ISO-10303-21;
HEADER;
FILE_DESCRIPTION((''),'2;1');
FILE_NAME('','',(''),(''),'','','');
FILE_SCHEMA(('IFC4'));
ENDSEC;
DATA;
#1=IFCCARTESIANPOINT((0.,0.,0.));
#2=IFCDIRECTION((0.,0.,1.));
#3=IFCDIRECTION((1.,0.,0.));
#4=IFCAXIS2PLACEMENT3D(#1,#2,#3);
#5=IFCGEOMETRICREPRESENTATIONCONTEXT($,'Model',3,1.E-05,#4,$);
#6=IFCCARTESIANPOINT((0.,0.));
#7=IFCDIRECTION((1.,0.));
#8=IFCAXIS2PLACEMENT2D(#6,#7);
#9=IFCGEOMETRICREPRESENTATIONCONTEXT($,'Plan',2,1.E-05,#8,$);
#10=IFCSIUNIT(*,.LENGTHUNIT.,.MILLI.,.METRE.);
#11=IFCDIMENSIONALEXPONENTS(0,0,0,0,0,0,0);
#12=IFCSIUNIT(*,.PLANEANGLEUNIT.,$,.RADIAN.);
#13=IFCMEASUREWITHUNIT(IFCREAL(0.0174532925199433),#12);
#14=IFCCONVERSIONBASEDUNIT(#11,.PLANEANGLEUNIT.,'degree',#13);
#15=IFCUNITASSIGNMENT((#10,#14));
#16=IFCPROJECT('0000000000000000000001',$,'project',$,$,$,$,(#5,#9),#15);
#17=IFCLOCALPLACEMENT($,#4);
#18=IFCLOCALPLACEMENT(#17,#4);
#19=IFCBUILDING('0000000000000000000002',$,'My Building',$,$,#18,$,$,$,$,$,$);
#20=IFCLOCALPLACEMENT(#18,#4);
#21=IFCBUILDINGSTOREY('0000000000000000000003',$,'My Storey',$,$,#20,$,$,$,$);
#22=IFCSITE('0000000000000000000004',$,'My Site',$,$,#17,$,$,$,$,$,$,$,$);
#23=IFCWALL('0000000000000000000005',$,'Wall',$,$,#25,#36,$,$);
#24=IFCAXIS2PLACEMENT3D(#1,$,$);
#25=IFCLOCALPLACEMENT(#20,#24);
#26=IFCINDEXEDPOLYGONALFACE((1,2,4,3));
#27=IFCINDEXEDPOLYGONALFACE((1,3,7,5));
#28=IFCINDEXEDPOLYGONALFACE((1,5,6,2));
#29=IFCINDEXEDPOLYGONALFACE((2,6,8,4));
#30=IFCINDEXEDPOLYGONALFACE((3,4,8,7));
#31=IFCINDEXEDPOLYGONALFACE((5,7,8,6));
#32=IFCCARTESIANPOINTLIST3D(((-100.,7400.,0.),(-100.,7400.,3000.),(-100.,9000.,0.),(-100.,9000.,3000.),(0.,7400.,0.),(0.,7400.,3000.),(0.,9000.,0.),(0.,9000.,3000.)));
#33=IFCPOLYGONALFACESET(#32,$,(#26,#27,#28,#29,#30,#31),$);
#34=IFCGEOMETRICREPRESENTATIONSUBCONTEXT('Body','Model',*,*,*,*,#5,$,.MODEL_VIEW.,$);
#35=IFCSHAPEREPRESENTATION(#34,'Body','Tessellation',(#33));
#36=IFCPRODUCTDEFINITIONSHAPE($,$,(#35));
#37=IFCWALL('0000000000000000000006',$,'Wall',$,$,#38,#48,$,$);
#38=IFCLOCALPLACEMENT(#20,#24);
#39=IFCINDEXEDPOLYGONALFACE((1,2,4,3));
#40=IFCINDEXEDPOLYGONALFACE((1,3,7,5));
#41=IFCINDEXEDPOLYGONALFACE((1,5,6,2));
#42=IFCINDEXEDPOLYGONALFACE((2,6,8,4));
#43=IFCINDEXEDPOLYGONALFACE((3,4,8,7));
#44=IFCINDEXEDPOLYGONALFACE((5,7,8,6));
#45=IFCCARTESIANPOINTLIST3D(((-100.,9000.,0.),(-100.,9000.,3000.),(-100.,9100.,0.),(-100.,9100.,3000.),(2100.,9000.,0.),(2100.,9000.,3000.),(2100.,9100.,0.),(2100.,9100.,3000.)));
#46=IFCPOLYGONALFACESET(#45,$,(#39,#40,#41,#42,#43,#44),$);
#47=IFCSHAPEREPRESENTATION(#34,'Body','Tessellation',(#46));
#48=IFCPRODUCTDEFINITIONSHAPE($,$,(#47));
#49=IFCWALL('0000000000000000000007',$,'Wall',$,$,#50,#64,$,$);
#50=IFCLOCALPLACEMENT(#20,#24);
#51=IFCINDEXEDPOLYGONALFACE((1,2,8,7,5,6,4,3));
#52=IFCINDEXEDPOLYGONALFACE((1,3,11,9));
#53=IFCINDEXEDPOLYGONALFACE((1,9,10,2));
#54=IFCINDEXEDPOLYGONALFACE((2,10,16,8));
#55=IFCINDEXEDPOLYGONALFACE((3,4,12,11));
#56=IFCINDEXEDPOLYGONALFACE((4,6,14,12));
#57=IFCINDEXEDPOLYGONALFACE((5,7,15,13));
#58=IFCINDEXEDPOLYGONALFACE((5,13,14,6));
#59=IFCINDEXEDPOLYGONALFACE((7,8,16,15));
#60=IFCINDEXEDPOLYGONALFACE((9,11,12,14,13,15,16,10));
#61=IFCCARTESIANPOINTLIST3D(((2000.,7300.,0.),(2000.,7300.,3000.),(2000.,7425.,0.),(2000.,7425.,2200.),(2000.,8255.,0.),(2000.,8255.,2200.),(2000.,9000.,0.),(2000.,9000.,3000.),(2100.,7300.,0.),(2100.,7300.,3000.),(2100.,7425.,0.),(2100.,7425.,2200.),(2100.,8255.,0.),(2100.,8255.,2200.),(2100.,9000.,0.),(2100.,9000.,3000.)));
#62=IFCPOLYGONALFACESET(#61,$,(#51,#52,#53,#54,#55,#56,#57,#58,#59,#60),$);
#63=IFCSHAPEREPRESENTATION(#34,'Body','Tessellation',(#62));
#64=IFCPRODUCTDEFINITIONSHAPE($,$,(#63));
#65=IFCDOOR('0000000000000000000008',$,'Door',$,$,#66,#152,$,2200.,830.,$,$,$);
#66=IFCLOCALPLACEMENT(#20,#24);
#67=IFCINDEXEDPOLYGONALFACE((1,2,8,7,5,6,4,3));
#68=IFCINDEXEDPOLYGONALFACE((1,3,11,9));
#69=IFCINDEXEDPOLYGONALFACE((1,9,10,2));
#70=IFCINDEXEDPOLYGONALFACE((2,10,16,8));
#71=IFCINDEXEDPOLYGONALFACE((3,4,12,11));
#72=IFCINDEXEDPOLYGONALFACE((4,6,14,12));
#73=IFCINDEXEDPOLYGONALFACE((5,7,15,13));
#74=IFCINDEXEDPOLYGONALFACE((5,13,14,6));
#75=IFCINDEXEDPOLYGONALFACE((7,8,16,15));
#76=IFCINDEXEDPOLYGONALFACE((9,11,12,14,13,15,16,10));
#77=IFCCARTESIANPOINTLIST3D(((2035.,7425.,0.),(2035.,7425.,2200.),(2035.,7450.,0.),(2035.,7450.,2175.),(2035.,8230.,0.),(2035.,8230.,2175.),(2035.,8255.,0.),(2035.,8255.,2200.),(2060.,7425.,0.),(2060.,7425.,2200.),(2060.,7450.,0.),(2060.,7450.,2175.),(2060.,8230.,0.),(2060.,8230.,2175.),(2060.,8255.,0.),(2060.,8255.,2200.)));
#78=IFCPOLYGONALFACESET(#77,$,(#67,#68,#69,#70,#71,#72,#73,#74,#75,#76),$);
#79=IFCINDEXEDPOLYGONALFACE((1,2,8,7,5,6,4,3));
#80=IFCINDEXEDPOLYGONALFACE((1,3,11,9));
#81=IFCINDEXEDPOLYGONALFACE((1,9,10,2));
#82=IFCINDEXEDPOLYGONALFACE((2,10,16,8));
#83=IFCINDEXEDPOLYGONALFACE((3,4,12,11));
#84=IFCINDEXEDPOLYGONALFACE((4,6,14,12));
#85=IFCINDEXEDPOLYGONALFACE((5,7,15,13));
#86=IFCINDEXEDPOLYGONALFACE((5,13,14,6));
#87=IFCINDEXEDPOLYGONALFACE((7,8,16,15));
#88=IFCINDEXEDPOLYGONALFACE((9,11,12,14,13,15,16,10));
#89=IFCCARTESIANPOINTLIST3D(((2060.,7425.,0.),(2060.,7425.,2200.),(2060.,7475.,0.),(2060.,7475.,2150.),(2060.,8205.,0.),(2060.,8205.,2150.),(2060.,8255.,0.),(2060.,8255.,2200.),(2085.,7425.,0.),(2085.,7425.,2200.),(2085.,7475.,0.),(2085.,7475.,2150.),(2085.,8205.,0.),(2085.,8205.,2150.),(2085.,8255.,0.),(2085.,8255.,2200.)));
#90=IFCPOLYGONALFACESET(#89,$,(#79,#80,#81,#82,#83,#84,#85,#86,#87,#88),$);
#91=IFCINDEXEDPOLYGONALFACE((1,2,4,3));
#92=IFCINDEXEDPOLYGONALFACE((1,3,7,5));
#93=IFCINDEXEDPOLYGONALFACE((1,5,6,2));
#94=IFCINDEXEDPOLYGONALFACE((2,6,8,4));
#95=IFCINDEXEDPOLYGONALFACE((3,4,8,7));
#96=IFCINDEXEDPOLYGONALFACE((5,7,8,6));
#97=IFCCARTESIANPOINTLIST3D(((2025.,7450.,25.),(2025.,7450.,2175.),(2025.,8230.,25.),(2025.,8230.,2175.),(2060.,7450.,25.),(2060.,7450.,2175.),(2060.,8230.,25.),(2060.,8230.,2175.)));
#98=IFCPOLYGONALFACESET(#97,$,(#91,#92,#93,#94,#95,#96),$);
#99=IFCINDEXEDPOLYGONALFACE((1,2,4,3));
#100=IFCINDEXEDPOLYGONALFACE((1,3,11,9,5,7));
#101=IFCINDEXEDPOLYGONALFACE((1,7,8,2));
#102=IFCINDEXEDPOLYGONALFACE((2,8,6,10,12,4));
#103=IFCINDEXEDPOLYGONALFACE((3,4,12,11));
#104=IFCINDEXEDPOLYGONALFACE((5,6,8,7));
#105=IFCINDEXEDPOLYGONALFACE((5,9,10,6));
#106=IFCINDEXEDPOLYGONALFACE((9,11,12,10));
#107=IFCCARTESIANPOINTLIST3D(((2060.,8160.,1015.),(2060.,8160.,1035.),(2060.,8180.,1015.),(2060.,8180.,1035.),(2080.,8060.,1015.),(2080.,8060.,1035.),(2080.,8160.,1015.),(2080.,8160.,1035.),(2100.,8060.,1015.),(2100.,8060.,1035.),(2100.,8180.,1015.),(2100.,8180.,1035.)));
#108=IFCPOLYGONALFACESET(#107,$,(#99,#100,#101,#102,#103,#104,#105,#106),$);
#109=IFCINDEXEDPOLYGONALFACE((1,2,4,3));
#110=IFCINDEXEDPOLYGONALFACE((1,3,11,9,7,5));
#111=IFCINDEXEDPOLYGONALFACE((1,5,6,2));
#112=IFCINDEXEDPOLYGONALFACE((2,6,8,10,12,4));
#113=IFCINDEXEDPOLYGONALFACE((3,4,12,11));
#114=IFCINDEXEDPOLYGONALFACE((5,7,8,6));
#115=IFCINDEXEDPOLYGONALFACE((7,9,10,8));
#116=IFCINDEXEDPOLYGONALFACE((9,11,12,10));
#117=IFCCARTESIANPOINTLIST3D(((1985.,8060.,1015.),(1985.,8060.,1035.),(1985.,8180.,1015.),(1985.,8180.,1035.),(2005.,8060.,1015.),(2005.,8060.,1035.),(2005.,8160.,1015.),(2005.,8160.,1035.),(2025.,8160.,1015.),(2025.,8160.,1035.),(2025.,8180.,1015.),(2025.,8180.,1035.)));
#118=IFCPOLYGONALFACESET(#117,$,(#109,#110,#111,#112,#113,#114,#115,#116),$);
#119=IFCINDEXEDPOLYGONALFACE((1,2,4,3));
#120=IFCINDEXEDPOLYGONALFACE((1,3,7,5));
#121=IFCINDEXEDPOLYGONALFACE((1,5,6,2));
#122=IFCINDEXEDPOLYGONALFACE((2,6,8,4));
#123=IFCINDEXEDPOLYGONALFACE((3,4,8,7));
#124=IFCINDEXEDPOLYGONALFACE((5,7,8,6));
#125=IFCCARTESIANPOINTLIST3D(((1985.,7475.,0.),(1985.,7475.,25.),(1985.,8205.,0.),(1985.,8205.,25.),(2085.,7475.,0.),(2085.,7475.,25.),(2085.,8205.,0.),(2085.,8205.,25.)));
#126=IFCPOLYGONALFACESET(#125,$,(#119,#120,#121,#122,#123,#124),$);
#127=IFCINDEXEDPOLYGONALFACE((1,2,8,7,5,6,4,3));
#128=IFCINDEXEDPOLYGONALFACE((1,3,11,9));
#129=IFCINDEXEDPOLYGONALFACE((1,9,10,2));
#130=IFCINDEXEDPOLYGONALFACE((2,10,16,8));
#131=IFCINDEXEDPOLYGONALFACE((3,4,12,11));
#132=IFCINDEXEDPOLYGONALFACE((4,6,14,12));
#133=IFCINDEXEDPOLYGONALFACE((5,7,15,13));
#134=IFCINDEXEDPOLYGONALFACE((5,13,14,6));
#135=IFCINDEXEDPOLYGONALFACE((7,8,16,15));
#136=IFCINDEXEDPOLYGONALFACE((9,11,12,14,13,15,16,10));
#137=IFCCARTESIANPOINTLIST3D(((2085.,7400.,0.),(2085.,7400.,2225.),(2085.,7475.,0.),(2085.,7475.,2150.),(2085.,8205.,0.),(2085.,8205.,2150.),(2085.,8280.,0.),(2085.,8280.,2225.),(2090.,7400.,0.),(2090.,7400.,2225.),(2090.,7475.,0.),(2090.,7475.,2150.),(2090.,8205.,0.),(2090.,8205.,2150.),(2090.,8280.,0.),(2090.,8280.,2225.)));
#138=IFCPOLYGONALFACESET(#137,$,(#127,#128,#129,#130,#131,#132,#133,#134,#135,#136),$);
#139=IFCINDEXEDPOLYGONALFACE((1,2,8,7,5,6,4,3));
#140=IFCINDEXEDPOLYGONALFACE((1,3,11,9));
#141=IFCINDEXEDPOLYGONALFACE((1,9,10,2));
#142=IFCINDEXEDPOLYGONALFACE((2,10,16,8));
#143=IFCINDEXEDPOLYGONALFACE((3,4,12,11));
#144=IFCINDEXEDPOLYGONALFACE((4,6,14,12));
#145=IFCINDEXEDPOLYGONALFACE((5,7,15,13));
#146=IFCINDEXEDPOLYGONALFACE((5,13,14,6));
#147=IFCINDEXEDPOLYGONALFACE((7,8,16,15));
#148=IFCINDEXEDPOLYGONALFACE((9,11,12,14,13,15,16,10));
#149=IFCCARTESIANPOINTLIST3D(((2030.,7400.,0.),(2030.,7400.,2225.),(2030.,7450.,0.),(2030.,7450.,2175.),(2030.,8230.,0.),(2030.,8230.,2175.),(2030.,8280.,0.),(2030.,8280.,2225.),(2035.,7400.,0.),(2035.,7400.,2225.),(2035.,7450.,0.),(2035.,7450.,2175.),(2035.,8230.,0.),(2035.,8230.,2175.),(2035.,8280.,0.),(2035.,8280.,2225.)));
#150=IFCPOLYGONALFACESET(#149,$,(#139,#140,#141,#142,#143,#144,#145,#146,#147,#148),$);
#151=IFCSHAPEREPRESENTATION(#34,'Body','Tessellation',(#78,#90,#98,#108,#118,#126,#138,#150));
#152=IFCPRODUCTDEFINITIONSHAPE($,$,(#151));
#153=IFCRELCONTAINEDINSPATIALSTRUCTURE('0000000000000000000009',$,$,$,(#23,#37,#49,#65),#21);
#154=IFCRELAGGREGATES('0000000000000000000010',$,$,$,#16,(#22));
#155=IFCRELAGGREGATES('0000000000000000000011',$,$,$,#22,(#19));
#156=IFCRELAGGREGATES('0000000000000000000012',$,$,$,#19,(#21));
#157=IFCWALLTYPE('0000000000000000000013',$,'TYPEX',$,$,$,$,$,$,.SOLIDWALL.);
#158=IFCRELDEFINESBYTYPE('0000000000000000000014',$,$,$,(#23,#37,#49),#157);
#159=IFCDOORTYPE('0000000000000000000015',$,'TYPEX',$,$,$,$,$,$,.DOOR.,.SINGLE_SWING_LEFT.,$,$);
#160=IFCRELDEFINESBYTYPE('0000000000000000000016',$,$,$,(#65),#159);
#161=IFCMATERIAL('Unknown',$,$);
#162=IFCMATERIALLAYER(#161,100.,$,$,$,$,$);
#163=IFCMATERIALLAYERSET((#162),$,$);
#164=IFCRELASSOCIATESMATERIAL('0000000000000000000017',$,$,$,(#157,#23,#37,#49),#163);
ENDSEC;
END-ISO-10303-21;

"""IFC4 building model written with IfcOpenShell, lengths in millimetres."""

from ifc_helpers import new_model, entity, si_unit, converted_unit, frame, origin_with_axes, origin_2d_with_axis, place, context, subcontext, project, spatial, line, indexed_curve, outline, extrude, shape, source, transform, mapped, material, layer, layer_set, layer_usage, type_object, type_shapes, element, fill, save


model = new_model("IFC4")

# Units and contexts
model_context = context("Model", 3, precision=1e-05, world=origin_with_axes())
plan_context = context("Plan", 2, precision=1e-05, world=origin_2d_with_axis())
body_context_1 = subcontext(model_context, "Body", "Model", "MODEL_VIEW")
body_context_2 = subcontext(plan_context, "Body", "Plan", "PLAN_VIEW")
ifc_project = project(units=[si_unit("LENGTHUNIT", "METRE", prefix="MILLI"), converted_unit("PLANEANGLEUNIT", "degree", entity("IfcReal", 0.0174532925199433), si_unit("PLANEANGLEUNIT", "RADIAN"), dimensions=[0, 0, 0, 0, 0, 0, 0])], contexts=[model_context, plan_context])

# Site, building, storey
site_placement = place(None, origin_with_axes())
site = spatial("IfcSite", under=ifc_project, at=site_placement, Name="My Site")
building_placement = place(site_placement, origin_with_axes())
building = spatial("IfcBuilding", under=site, at=building_placement, Name="My Building")
storey_placement = place(building_placement, origin_with_axes())
storey = spatial("IfcBuildingStorey", under=building, at=storey_placement, Name="My Storey")

# Shared definitions
ifc_material = material(Name="Unknown")

# Shared definitions
ifc_layer_1 = layer(ifc_material, 100.0)
ifc_layer_set_1 = layer_set([ifc_layer_1])
wall_type = type_object("IfcWallType", Name="TYPEX", PredefinedType="SOLIDWALL", material=ifc_layer_set_1)
shared_shape_1 = source(origin_with_axes(), body_context_1, "Body", "SweptSolid", [
    extrude(outline(indexed_curve([(0.0, 0.0), (830.0, 0.0), (830.0, 2200.0), (0.0, 2200.0)], segments=[line(1, 2, 3, 4, 1)])), frame((0.0, -100.0, 0.0), z_axis=(0.0, -1.0, 0.0), x_axis=(1.0, 0.0, 0.0)), (0.0, 0.0, -1.0), 300.0),
])
door_type = type_object("IfcDoorType", Name="TYPEX", OperationType="SINGLE_SWING_LEFT", PredefinedType="DOOR")
shared_shape_2 = source(origin_with_axes(), body_context_1, "Body", "SweptSolid", [
    extrude(outline(indexed_curve([(0.0, 0.0), (0.0, 2200.0), (830.0, 2200.0), (830.0, 0.0), (805.0, 0.0), (805.0, 2175.0), (25.0, 2175.0), (25.0, 0.0)], segments=[line(1, 2, 3, 4, 5, 6, 7, 8, 1)])), frame((0.0, 25.0, 0.0), z_axis=(0.0, -1.0, 0.0), x_axis=(1.0, 0.0, 0.0)), (0.0, 0.0, -1.0), 25.0),
    extrude(outline(indexed_curve([(0.0, 0.0), (0.0, 2200.0), (830.0, 2200.0), (830.0, 0.0), (780.0, 0.0), (780.0, 2150.0), (50.0, 2150.0), (50.0, 0.0)], segments=[line(1, 2, 3, 4, 5, 6, 7, 8, 1)])), frame((0.0, 0.0, 0.0), z_axis=(0.0, -1.0, 0.0), x_axis=(1.0, 0.0, 0.0)), (0.0, 0.0, -1.0), 25.0),
    extrude(outline(indexed_curve([(0.0, 0.0), (780.0, 0.0), (780.0, 35.0), (0.0, 35.0)], segments=[line(1, 2, 3, 4, 1)])), frame((25.0, 25.0, 25.0), z_axis=(0.0, 0.0, 1.0), x_axis=(1.0, 0.0, 0.0)), (0.0, 0.0, 1.0), 2150.0),
    extrude(outline(indexed_curve([(0.0, 0.0), (0.0, -40.0), (-120.0, -40.0), (-120.0, -20.0), (-20.0, -20.0), (-20.0, 0.0)], segments=[line(1, 2, 3, 4, 5, 6, 1)])), frame((755.0, 25.0, 1015.0), z_axis=(0.0, 0.0, 1.0), x_axis=(1.0, 0.0, 0.0)), (0.0, 0.0, 1.0), 20.0),
    extrude(outline(indexed_curve([(0.0, 0.0), (0.0, 40.0), (-120.0, 40.0), (-120.0, 20.0), (-20.0, 20.0), (-20.0, 0.0)], segments=[line(1, 2, 3, 4, 5, 6, 1)])), frame((755.0, 60.0, 1015.0), z_axis=(0.0, 0.0, 1.0), x_axis=(1.0, 0.0, 0.0)), (0.0, 0.0, 1.0), 20.0),
    extrude(outline(indexed_curve([(0.0, 0.0), (730.0, 0.0), (730.0, 100.0), (0.0, 100.0)], segments=[line(1, 2, 3, 4, 1)])), frame((50.0, 0.0, 0.0), z_axis=(0.0, 0.0, 1.0), x_axis=(1.0, 0.0, 0.0)), (0.0, 0.0, 1.0), 25.0),
    extrude(outline(indexed_curve([(0.0, 0.0), (0.0, 2225.0), (880.0, 2225.0), (880.0, 0.0), (805.0, 0.0), (805.0, 2150.0), (75.0, 2150.0), (75.0, 0.0)], segments=[line(1, 2, 3, 4, 5, 6, 7, 8, 1)])), frame((-25.0, -5.0, 0.0), z_axis=(0.0, -1.0, 0.0), x_axis=(1.0, 0.0, 0.0)), (0.0, 0.0, -1.0), 5.0),
    extrude(outline(indexed_curve([(0.0, 0.0), (0.0, 2225.0), (880.0, 2225.0), (880.0, 0.0), (830.0, 0.0), (830.0, 2175.0), (50.0, 2175.0), (50.0, 0.0)], segments=[line(1, 2, 3, 4, 5, 6, 7, 8, 1)])), frame((-25.0, 50.0, 0.0), z_axis=(0.0, -1.0, 0.0), x_axis=(1.0, 0.0, 0.0)), (0.0, 0.0, -1.0), 5.0),
])
shared_shape_3 = source(origin_with_axes(), body_context_2, "Body", "Curve2D", [
    entity("IfcIndexedPolyCurve", entity("IfcCartesianPointList2D", [[0.0, 0.0], [0.0, 50.0], [25.0, 50.0], [25.0, 25.0], [50.0, 25.0], [50.0, 0.0]]), [entity("IfcLineIndex", [1, 2, 3, 4, 5, 6, 1])]),
    entity("IfcIndexedPolyCurve", entity("IfcCartesianPointList2D", [[830.0, 0.0], [830.0, 50.0], [805.0, 50.0], [805.0, 25.0], [780.0, 25.0], [780.0, 0.0]]), [entity("IfcLineIndex", [1, 2, 3, 4, 5, 6, 1])]),
    entity("IfcTrimmedCurve", entity("IfcEllipse", entity("IfcAxis2Placement2D", entity("IfcCartesianPoint", [60.0, 50.0]), entity("IfcDirection", [1.0, 0.0])), 745.0, 780.0), [entity("IfcCartesianPoint", [805.0, 50.0])], [entity("IfcCartesianPoint", [60.0, 830.0])], True, "CARTESIAN"),
    entity("IfcIndexedPolyCurve", entity("IfcCartesianPointList2D", [[25.0, 50.0], [60.0, 50.0], [60.0, 830.0], [25.0, 830.0]]), [entity("IfcLineIndex", [1, 2, 3, 4, 1])]),
])
type_shapes(door_type, [shared_shape_2, shared_shape_3])

# Walls
ifc_layer_usage_1 = layer_usage(ifc_layer_set_1, "AXIS2", "POSITIVE", 0.0)
wall_1_placement = place(storey_placement, frame((0.0, 7400.0, 0.0), z_axis=(0.0, 0.0, 1.0), x_axis=(0.000001, 1.0, 0.0)))
element("IfcWall", 1, at=wall_1_placement, inside=storey, type_object=wall_type, material=ifc_layer_usage_1, Name="Wall", context=body_context_1, shape_type="SweptSolid", body=[
    extrude(outline(indexed_curve([(0.0, 0.0), (0.0, 100.0), (1600.0, 100.0), (1600.0, 0.0), (0.0, 0.0)], self_intersect=False)), origin_with_axes(), (0.0, 0.0, 1.0), 3000.0),
])
ifc_layer_usage_2 = layer_usage(ifc_layer_set_1, "AXIS2", "POSITIVE", 0.0)
wall_2_placement = place(storey_placement, frame((-100.0, 9000.0, 0.0), z_axis=(0.0, 0.0, 1.0), x_axis=(1.0, -0.000001, 0.0)))
element("IfcWall", 2, at=wall_2_placement, inside=storey, type_object=wall_type, material=ifc_layer_usage_2, Name="Wall", context=body_context_1, shape_type="SweptSolid", body=[
    extrude(outline(indexed_curve([(0.0, 0.0), (0.0, 100.0), (2200.0, 100.0), (2200.0, 0.0), (0.0, 0.0)], self_intersect=False)), origin_with_axes(), (0.0, 0.0, 1.0), 3000.0),
])

# Wall, opening, door
ifc_layer_usage_3 = layer_usage(ifc_layer_set_1, "AXIS2", "POSITIVE", 0.0)
wall_3_placement = place(storey_placement, frame((2000.0, 9000.0, 0.0), z_axis=(0.0, 0.0, 1.0), x_axis=(-0.000001, -1.0, 0.0)))
wall_3 = element("IfcWall", 3, at=wall_3_placement, inside=storey, type_object=wall_type, material=ifc_layer_usage_3, Name="Wall", context=body_context_1, shape_type="SweptSolid", body=[
    extrude(outline(indexed_curve([(0.0, 0.0), (0.0, 100.0), (1700.0, 100.0), (1700.0, 0.0), (0.0, 0.0)], self_intersect=False)), origin_with_axes(), (0.0, 0.0, 1.0), 3000.0),
])
opening_1_placement = place(wall_3_placement, frame((1575.0, 85.0, 0.0), z_axis=(0.0, 0.0, 1.0), x_axis=(-1.0, 0.0, 0.0)))
opening_1 = element("IfcOpeningElement", 4, at=opening_1_placement, cuts=wall_3, PredefinedType="OPENING", context=body_context_1, shape_type="MappedRepresentation", body=[
    mapped(shared_shape_1, transform((0.0, 0.0, 0.0), x_axis=(1.0, 0.0, 0.0), y_axis=(0.0, 1.0, 0.0), z_axis=(0.0, 0.0, 1.0), scale=1.0)),
])
door_1_placement = place(opening_1_placement, frame((0.0, 0.0, 0.0), z_axis=(0.0, 0.0, 1.0), x_axis=(1.0, 0.0, 0.0)))
door_1 = element("IfcDoor", 5, at=door_1_placement, inside=storey, type_object=door_type, Name="Door", OverallHeight=2200.0, OverallWidth=830.0, shapes=[
    shape(body_context_1, "Body", "MappedRepresentation", [mapped(shared_shape_2, transform((0.0, 0.0, 0.0), x_axis=(1.0, 0.0, 0.0), y_axis=(0.0, 1.0, 0.0), z_axis=(0.0, 0.0, 1.0), scale=1.0))]),
    shape(body_context_2, "Body", "MappedRepresentation", [mapped(shared_shape_3, transform((0.0, 0.0, 0.0), x_axis=(1.0, 0.0, 0.0), y_axis=(0.0, 1.0, 0.0), z_axis=(0.0, 0.0, 1.0), scale=1.0))]),
])
fill(opening_1, door_1)

save(model, "model.ifc")
